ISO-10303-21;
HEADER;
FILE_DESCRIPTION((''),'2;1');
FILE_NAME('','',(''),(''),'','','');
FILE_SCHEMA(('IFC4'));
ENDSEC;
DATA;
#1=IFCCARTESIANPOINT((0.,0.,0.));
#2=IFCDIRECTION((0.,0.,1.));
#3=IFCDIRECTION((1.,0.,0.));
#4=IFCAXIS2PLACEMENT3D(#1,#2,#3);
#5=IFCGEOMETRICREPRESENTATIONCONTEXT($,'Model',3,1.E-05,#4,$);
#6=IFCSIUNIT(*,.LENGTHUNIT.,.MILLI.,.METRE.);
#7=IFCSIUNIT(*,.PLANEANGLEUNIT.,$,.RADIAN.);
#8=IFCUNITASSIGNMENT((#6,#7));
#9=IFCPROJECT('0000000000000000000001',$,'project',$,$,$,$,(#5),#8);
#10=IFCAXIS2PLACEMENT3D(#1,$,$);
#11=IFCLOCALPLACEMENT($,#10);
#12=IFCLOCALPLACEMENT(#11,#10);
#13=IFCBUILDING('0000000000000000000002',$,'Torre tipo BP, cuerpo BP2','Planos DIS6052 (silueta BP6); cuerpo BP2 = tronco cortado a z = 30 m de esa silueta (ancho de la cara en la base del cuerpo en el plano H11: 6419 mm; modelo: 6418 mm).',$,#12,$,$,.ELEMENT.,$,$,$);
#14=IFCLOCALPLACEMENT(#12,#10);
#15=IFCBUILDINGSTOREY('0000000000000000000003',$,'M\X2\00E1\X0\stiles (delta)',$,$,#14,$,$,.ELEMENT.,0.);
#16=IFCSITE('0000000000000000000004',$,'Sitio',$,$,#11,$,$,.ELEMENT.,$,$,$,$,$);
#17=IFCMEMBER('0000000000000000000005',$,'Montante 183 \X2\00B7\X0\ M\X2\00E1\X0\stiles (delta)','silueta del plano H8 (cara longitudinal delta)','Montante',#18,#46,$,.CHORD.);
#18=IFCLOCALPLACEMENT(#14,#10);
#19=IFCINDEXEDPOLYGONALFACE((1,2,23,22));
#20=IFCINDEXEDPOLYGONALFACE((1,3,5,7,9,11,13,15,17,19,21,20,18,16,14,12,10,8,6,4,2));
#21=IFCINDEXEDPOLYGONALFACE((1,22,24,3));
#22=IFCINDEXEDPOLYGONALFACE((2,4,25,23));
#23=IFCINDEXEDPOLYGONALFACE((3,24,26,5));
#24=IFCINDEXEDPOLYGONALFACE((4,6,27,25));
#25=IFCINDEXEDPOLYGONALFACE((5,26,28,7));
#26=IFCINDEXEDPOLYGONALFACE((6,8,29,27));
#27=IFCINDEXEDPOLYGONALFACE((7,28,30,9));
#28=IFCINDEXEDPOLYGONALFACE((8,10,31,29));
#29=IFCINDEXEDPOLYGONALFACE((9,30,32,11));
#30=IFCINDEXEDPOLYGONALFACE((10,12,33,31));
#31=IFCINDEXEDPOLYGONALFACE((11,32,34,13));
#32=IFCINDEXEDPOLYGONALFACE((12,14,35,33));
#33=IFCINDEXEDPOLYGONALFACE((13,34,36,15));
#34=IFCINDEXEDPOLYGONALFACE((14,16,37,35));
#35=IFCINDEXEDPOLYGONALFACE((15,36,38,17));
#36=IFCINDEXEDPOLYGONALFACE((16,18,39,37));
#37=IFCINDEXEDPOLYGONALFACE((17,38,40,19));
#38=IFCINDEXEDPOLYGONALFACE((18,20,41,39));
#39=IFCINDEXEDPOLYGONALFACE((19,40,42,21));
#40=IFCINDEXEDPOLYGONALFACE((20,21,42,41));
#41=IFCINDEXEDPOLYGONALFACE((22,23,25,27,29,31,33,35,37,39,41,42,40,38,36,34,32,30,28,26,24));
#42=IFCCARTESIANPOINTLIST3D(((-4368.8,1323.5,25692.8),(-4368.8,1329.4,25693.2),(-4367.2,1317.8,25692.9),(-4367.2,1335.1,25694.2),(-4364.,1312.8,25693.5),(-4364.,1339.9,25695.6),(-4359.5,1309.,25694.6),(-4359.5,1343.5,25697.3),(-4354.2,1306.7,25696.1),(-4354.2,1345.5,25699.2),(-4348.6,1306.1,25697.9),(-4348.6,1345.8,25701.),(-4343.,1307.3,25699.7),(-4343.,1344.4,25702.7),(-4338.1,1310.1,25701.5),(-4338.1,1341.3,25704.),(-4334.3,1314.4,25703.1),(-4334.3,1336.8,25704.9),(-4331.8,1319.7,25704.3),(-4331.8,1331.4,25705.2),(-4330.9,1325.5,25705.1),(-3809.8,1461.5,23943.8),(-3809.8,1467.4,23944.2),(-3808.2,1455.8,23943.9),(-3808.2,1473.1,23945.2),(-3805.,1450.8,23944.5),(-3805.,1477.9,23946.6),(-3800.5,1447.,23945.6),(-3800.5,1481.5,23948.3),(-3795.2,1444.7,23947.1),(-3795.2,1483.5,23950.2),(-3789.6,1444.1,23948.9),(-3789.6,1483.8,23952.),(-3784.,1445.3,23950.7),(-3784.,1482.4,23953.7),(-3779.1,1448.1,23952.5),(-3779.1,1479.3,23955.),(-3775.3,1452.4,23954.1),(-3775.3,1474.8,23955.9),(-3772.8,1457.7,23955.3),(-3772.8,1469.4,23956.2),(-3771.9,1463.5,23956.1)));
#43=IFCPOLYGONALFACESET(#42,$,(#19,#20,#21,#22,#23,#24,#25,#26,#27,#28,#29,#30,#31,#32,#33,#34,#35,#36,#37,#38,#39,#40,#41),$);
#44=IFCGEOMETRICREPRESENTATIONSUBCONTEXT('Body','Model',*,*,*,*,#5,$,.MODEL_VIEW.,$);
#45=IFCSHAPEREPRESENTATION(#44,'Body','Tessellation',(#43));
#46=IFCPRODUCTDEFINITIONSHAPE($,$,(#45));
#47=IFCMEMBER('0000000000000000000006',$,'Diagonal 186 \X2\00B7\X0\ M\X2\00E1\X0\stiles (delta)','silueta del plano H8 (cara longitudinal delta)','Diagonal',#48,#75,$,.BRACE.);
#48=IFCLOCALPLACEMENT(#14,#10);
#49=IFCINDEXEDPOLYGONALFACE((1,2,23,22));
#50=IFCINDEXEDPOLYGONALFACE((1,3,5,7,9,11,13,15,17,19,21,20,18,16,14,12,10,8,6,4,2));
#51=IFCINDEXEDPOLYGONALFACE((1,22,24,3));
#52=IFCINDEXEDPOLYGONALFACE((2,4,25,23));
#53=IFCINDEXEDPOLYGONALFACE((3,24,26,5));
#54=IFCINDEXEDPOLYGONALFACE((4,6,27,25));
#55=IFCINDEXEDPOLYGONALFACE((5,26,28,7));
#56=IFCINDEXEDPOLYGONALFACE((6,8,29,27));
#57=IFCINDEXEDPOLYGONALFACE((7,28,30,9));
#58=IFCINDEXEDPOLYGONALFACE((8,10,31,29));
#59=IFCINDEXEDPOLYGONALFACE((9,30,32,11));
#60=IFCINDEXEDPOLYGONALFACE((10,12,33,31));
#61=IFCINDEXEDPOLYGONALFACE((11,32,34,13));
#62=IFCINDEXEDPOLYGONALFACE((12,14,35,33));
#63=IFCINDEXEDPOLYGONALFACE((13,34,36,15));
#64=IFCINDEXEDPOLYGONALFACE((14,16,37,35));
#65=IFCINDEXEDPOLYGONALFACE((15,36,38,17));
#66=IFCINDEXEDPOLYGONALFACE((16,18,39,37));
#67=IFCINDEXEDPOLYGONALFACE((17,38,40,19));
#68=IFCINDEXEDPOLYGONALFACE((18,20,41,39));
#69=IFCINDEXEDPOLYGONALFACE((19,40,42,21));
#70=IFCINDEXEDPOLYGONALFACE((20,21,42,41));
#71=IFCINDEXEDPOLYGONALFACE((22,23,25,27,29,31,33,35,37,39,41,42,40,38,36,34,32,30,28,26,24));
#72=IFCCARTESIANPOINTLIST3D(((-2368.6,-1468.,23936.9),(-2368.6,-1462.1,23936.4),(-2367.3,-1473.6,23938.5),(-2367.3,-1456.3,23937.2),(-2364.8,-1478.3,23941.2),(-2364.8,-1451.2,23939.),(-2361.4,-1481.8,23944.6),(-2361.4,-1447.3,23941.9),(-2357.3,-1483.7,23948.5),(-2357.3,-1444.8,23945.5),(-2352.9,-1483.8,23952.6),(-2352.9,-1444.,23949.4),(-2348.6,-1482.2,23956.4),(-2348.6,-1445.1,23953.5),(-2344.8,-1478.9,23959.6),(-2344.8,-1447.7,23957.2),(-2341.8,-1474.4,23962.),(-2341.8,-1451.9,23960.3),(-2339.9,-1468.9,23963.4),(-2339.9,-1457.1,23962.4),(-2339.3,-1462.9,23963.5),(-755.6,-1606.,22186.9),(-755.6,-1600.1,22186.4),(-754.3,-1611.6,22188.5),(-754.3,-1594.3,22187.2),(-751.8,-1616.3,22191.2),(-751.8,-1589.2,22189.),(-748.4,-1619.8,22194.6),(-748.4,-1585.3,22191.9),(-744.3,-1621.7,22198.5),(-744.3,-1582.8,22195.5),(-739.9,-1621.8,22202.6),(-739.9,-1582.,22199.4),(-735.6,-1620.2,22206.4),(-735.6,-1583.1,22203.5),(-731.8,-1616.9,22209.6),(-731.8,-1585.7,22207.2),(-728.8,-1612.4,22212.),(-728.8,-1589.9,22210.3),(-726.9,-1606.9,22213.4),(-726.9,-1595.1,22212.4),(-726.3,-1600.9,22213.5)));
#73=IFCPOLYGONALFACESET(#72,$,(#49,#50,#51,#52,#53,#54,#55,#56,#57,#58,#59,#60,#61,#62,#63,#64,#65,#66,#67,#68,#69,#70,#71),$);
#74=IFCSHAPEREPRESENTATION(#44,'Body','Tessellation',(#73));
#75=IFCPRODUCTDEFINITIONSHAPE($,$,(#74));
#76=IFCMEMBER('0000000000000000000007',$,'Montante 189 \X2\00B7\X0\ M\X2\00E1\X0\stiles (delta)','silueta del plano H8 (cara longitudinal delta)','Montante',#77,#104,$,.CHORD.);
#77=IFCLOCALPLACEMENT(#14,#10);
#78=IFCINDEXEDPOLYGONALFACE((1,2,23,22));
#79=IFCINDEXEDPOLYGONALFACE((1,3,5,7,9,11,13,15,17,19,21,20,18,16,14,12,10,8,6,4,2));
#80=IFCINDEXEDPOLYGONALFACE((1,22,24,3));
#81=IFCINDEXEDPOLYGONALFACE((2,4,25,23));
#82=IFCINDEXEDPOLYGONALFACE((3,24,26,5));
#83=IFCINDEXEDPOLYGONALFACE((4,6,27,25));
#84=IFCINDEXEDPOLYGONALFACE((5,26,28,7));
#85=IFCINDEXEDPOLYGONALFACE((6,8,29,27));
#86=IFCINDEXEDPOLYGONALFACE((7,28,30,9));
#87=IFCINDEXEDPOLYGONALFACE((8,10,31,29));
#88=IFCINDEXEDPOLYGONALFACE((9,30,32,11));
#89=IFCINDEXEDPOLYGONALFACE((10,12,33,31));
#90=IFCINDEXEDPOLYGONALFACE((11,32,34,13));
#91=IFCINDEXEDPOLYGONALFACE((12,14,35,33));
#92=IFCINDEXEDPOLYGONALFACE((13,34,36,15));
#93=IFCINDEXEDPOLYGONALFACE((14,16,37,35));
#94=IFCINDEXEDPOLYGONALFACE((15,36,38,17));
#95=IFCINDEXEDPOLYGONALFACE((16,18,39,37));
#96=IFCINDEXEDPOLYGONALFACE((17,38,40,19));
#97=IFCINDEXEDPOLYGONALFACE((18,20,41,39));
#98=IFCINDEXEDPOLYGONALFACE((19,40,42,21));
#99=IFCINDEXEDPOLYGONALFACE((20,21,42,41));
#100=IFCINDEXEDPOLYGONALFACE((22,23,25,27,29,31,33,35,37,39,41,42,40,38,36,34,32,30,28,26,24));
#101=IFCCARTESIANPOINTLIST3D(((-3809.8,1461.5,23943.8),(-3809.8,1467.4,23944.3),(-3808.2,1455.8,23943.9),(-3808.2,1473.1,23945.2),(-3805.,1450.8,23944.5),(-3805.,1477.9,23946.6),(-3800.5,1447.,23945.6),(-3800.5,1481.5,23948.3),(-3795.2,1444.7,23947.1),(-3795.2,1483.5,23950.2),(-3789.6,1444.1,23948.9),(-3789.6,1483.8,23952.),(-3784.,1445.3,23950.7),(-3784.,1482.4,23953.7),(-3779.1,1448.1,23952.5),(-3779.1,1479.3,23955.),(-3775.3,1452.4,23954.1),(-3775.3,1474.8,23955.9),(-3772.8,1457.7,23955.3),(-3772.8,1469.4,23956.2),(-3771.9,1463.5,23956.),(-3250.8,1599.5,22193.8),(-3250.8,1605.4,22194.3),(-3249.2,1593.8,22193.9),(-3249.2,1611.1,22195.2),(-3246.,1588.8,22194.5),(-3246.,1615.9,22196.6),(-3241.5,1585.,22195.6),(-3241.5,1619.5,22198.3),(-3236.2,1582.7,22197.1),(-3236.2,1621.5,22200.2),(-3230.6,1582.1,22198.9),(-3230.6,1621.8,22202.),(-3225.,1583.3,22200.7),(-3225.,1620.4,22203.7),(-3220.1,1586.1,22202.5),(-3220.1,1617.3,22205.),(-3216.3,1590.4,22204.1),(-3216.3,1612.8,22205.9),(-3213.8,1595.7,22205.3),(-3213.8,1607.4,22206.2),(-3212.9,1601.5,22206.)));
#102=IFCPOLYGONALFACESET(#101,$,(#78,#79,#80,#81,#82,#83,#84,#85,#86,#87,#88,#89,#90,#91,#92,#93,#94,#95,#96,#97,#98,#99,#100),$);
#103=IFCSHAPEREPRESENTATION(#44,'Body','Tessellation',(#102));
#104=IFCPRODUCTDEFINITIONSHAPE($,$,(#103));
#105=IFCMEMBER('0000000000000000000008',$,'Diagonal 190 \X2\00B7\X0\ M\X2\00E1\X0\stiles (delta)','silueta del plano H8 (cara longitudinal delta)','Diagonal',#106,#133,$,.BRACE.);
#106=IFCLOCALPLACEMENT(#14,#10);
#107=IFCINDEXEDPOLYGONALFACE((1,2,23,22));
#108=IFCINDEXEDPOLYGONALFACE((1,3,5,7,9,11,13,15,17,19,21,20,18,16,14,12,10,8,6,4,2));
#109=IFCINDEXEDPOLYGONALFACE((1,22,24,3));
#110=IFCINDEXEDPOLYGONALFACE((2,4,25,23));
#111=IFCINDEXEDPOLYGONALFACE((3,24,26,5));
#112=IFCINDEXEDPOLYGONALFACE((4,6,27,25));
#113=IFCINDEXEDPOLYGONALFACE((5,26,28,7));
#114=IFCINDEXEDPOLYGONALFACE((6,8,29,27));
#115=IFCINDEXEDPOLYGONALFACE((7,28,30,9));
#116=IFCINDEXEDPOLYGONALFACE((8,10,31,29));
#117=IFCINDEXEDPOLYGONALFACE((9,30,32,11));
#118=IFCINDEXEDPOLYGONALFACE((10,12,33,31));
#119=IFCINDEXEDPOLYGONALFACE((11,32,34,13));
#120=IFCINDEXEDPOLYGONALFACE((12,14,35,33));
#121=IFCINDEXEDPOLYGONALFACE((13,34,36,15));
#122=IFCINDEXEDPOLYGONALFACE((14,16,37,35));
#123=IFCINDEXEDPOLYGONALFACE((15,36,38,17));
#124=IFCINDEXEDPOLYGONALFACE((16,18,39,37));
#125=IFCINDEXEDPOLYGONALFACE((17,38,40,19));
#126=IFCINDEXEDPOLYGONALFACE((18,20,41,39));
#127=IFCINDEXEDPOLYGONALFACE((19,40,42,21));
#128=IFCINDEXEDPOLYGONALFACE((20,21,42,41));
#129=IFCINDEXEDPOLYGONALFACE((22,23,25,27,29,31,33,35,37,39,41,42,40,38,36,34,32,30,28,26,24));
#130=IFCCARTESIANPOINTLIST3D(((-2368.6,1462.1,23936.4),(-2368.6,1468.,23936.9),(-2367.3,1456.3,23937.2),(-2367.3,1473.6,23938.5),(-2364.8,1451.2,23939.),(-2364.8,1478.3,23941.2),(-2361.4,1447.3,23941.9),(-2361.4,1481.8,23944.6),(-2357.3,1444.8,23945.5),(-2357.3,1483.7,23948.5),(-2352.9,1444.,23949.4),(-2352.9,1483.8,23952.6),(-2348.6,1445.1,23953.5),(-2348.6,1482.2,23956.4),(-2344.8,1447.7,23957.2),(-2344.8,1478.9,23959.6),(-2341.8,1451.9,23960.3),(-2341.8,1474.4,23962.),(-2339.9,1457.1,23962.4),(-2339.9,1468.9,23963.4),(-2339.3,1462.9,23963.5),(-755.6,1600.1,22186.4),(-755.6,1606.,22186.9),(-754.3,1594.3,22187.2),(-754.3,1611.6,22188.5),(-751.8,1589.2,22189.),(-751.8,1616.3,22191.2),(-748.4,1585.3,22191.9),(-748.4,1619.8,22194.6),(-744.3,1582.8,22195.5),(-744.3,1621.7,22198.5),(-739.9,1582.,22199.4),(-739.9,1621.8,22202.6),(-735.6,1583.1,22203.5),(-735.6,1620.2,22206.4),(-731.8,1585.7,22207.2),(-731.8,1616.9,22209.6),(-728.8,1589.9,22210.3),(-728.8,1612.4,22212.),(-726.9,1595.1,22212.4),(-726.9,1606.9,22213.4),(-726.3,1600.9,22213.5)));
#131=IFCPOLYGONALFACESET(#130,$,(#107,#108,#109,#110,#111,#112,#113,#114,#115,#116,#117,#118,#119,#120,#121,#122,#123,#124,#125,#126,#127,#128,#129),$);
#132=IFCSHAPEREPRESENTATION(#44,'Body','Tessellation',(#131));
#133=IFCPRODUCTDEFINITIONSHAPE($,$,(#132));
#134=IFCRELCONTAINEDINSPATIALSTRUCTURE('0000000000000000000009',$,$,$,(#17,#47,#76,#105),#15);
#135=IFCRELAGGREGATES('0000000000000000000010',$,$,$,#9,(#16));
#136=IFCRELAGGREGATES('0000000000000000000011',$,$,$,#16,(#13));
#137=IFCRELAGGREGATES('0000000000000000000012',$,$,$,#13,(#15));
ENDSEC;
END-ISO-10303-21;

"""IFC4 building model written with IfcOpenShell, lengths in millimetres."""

from ifc_helpers import new_model, si_unit, frame, origin, origin_with_axes, place, context, subcontext, project, spatial, circle, extrude, element, save


model = new_model("IFC4")

# Units and contexts
model_context = context("Model", 3, precision=1e-05, world=origin_with_axes())
body_context = subcontext(model_context, "Body", "Model", "MODEL_VIEW")
ifc_project = project(units=[si_unit("LENGTHUNIT", "METRE", prefix="MILLI"), si_unit("PLANEANGLEUNIT", "RADIAN")], contexts=[model_context])

# Site, building, storey
site_placement = place(None, origin())
site = spatial("IfcSite", under=ifc_project, at=site_placement, Name="Sitio", CompositionType="ELEMENT")
building_placement = place(site_placement, origin())
building = spatial("IfcBuilding", under=site, at=building_placement, Name="Torre tipo BP, cuerpo BP2", Description="Planos DIS6052 (silueta BP6); cuerpo BP2 = tronco cortado a z = 30 m de esa silueta (ancho de la cara en la base del cuerpo en el plano H11: 6419 mm; modelo: 6418 mm).", CompositionType="ELEMENT")
storey_placement = place(building_placement, origin())
storey = spatial("IfcBuildingStorey", under=building, at=storey_placement, Name="Mástiles (delta)", CompositionType="ELEMENT", Elevation=0.0)

# Members
for number, where, z_axis, x_axis, name in (
    (1, (-4350.0, 1326.0, 25699.0), (0.303584, 0.074945, -0.949853), (0.952805, -0.023879, 0.302643), "Montante 183 · Mástiles (delta)"),
):
    element("IfcMember", number, at=place(storey_placement, frame(where, z_axis=z_axis, x_axis=x_axis)), inside=storey, Name=name, Description="silueta del plano H8 (cara longitudinal delta)", ObjectType="Montante", PredefinedType="CHORD", context=body_context, shape_type="SweptSolid", body=[
        extrude(circle(Radius=20.0), None, (0.0, 0.0, 1.0), 1841.3),
    ])
member_1_placement = place(storey_placement, frame((-2354.0, -1464.0, 23950.0), z_axis=(0.676602, -0.057887, -0.73407), x_axis=(0.736348, 0.05319, 0.674509)))
element("IfcMember", 2, at=member_1_placement, inside=storey, Name="Diagonal 186 · Mástiles (delta)", Description="silueta del plano H8 (cara longitudinal delta)", ObjectType="Diagonal", PredefinedType="BRACE", context=body_context, shape_type="SweptSolid", body=[
    extrude(circle(Radius=20.0), None, (0.0, 0.0, 1.0), 2384.0),
])
member_2_placement = place(storey_placement, frame((-3791.0, 1464.0, 23950.0), z_axis=(0.303427, 0.074907, -0.949906), x_axis=(0.952855, -0.023853, 0.302488)))
element("IfcMember", 3, at=member_2_placement, inside=storey, Name="Montante 189 · Mástiles (delta)", Description="silueta del plano H8 (cara longitudinal delta)", ObjectType="Montante", PredefinedType="CHORD", context=body_context, shape_type="SweptSolid", body=[
    extrude(circle(Radius=20.0), None, (0.0, 0.0, 1.0), 1842.3),
])
member_3_placement = place(storey_placement, frame((-2354.0, 1464.0, 23950.0), z_axis=(0.676602, 0.057887, -0.73407), x_axis=(0.736348, -0.05319, 0.674509)))
element("IfcMember", 4, at=member_3_placement, inside=storey, Name="Diagonal 190 · Mástiles (delta)", Description="silueta del plano H8 (cara longitudinal delta)", ObjectType="Diagonal", PredefinedType="BRACE", context=body_context, shape_type="SweptSolid", body=[
    extrude(circle(Radius=20.0), None, (0.0, 0.0, 1.0), 2384.0),
])

save(model, "model.ifc")
